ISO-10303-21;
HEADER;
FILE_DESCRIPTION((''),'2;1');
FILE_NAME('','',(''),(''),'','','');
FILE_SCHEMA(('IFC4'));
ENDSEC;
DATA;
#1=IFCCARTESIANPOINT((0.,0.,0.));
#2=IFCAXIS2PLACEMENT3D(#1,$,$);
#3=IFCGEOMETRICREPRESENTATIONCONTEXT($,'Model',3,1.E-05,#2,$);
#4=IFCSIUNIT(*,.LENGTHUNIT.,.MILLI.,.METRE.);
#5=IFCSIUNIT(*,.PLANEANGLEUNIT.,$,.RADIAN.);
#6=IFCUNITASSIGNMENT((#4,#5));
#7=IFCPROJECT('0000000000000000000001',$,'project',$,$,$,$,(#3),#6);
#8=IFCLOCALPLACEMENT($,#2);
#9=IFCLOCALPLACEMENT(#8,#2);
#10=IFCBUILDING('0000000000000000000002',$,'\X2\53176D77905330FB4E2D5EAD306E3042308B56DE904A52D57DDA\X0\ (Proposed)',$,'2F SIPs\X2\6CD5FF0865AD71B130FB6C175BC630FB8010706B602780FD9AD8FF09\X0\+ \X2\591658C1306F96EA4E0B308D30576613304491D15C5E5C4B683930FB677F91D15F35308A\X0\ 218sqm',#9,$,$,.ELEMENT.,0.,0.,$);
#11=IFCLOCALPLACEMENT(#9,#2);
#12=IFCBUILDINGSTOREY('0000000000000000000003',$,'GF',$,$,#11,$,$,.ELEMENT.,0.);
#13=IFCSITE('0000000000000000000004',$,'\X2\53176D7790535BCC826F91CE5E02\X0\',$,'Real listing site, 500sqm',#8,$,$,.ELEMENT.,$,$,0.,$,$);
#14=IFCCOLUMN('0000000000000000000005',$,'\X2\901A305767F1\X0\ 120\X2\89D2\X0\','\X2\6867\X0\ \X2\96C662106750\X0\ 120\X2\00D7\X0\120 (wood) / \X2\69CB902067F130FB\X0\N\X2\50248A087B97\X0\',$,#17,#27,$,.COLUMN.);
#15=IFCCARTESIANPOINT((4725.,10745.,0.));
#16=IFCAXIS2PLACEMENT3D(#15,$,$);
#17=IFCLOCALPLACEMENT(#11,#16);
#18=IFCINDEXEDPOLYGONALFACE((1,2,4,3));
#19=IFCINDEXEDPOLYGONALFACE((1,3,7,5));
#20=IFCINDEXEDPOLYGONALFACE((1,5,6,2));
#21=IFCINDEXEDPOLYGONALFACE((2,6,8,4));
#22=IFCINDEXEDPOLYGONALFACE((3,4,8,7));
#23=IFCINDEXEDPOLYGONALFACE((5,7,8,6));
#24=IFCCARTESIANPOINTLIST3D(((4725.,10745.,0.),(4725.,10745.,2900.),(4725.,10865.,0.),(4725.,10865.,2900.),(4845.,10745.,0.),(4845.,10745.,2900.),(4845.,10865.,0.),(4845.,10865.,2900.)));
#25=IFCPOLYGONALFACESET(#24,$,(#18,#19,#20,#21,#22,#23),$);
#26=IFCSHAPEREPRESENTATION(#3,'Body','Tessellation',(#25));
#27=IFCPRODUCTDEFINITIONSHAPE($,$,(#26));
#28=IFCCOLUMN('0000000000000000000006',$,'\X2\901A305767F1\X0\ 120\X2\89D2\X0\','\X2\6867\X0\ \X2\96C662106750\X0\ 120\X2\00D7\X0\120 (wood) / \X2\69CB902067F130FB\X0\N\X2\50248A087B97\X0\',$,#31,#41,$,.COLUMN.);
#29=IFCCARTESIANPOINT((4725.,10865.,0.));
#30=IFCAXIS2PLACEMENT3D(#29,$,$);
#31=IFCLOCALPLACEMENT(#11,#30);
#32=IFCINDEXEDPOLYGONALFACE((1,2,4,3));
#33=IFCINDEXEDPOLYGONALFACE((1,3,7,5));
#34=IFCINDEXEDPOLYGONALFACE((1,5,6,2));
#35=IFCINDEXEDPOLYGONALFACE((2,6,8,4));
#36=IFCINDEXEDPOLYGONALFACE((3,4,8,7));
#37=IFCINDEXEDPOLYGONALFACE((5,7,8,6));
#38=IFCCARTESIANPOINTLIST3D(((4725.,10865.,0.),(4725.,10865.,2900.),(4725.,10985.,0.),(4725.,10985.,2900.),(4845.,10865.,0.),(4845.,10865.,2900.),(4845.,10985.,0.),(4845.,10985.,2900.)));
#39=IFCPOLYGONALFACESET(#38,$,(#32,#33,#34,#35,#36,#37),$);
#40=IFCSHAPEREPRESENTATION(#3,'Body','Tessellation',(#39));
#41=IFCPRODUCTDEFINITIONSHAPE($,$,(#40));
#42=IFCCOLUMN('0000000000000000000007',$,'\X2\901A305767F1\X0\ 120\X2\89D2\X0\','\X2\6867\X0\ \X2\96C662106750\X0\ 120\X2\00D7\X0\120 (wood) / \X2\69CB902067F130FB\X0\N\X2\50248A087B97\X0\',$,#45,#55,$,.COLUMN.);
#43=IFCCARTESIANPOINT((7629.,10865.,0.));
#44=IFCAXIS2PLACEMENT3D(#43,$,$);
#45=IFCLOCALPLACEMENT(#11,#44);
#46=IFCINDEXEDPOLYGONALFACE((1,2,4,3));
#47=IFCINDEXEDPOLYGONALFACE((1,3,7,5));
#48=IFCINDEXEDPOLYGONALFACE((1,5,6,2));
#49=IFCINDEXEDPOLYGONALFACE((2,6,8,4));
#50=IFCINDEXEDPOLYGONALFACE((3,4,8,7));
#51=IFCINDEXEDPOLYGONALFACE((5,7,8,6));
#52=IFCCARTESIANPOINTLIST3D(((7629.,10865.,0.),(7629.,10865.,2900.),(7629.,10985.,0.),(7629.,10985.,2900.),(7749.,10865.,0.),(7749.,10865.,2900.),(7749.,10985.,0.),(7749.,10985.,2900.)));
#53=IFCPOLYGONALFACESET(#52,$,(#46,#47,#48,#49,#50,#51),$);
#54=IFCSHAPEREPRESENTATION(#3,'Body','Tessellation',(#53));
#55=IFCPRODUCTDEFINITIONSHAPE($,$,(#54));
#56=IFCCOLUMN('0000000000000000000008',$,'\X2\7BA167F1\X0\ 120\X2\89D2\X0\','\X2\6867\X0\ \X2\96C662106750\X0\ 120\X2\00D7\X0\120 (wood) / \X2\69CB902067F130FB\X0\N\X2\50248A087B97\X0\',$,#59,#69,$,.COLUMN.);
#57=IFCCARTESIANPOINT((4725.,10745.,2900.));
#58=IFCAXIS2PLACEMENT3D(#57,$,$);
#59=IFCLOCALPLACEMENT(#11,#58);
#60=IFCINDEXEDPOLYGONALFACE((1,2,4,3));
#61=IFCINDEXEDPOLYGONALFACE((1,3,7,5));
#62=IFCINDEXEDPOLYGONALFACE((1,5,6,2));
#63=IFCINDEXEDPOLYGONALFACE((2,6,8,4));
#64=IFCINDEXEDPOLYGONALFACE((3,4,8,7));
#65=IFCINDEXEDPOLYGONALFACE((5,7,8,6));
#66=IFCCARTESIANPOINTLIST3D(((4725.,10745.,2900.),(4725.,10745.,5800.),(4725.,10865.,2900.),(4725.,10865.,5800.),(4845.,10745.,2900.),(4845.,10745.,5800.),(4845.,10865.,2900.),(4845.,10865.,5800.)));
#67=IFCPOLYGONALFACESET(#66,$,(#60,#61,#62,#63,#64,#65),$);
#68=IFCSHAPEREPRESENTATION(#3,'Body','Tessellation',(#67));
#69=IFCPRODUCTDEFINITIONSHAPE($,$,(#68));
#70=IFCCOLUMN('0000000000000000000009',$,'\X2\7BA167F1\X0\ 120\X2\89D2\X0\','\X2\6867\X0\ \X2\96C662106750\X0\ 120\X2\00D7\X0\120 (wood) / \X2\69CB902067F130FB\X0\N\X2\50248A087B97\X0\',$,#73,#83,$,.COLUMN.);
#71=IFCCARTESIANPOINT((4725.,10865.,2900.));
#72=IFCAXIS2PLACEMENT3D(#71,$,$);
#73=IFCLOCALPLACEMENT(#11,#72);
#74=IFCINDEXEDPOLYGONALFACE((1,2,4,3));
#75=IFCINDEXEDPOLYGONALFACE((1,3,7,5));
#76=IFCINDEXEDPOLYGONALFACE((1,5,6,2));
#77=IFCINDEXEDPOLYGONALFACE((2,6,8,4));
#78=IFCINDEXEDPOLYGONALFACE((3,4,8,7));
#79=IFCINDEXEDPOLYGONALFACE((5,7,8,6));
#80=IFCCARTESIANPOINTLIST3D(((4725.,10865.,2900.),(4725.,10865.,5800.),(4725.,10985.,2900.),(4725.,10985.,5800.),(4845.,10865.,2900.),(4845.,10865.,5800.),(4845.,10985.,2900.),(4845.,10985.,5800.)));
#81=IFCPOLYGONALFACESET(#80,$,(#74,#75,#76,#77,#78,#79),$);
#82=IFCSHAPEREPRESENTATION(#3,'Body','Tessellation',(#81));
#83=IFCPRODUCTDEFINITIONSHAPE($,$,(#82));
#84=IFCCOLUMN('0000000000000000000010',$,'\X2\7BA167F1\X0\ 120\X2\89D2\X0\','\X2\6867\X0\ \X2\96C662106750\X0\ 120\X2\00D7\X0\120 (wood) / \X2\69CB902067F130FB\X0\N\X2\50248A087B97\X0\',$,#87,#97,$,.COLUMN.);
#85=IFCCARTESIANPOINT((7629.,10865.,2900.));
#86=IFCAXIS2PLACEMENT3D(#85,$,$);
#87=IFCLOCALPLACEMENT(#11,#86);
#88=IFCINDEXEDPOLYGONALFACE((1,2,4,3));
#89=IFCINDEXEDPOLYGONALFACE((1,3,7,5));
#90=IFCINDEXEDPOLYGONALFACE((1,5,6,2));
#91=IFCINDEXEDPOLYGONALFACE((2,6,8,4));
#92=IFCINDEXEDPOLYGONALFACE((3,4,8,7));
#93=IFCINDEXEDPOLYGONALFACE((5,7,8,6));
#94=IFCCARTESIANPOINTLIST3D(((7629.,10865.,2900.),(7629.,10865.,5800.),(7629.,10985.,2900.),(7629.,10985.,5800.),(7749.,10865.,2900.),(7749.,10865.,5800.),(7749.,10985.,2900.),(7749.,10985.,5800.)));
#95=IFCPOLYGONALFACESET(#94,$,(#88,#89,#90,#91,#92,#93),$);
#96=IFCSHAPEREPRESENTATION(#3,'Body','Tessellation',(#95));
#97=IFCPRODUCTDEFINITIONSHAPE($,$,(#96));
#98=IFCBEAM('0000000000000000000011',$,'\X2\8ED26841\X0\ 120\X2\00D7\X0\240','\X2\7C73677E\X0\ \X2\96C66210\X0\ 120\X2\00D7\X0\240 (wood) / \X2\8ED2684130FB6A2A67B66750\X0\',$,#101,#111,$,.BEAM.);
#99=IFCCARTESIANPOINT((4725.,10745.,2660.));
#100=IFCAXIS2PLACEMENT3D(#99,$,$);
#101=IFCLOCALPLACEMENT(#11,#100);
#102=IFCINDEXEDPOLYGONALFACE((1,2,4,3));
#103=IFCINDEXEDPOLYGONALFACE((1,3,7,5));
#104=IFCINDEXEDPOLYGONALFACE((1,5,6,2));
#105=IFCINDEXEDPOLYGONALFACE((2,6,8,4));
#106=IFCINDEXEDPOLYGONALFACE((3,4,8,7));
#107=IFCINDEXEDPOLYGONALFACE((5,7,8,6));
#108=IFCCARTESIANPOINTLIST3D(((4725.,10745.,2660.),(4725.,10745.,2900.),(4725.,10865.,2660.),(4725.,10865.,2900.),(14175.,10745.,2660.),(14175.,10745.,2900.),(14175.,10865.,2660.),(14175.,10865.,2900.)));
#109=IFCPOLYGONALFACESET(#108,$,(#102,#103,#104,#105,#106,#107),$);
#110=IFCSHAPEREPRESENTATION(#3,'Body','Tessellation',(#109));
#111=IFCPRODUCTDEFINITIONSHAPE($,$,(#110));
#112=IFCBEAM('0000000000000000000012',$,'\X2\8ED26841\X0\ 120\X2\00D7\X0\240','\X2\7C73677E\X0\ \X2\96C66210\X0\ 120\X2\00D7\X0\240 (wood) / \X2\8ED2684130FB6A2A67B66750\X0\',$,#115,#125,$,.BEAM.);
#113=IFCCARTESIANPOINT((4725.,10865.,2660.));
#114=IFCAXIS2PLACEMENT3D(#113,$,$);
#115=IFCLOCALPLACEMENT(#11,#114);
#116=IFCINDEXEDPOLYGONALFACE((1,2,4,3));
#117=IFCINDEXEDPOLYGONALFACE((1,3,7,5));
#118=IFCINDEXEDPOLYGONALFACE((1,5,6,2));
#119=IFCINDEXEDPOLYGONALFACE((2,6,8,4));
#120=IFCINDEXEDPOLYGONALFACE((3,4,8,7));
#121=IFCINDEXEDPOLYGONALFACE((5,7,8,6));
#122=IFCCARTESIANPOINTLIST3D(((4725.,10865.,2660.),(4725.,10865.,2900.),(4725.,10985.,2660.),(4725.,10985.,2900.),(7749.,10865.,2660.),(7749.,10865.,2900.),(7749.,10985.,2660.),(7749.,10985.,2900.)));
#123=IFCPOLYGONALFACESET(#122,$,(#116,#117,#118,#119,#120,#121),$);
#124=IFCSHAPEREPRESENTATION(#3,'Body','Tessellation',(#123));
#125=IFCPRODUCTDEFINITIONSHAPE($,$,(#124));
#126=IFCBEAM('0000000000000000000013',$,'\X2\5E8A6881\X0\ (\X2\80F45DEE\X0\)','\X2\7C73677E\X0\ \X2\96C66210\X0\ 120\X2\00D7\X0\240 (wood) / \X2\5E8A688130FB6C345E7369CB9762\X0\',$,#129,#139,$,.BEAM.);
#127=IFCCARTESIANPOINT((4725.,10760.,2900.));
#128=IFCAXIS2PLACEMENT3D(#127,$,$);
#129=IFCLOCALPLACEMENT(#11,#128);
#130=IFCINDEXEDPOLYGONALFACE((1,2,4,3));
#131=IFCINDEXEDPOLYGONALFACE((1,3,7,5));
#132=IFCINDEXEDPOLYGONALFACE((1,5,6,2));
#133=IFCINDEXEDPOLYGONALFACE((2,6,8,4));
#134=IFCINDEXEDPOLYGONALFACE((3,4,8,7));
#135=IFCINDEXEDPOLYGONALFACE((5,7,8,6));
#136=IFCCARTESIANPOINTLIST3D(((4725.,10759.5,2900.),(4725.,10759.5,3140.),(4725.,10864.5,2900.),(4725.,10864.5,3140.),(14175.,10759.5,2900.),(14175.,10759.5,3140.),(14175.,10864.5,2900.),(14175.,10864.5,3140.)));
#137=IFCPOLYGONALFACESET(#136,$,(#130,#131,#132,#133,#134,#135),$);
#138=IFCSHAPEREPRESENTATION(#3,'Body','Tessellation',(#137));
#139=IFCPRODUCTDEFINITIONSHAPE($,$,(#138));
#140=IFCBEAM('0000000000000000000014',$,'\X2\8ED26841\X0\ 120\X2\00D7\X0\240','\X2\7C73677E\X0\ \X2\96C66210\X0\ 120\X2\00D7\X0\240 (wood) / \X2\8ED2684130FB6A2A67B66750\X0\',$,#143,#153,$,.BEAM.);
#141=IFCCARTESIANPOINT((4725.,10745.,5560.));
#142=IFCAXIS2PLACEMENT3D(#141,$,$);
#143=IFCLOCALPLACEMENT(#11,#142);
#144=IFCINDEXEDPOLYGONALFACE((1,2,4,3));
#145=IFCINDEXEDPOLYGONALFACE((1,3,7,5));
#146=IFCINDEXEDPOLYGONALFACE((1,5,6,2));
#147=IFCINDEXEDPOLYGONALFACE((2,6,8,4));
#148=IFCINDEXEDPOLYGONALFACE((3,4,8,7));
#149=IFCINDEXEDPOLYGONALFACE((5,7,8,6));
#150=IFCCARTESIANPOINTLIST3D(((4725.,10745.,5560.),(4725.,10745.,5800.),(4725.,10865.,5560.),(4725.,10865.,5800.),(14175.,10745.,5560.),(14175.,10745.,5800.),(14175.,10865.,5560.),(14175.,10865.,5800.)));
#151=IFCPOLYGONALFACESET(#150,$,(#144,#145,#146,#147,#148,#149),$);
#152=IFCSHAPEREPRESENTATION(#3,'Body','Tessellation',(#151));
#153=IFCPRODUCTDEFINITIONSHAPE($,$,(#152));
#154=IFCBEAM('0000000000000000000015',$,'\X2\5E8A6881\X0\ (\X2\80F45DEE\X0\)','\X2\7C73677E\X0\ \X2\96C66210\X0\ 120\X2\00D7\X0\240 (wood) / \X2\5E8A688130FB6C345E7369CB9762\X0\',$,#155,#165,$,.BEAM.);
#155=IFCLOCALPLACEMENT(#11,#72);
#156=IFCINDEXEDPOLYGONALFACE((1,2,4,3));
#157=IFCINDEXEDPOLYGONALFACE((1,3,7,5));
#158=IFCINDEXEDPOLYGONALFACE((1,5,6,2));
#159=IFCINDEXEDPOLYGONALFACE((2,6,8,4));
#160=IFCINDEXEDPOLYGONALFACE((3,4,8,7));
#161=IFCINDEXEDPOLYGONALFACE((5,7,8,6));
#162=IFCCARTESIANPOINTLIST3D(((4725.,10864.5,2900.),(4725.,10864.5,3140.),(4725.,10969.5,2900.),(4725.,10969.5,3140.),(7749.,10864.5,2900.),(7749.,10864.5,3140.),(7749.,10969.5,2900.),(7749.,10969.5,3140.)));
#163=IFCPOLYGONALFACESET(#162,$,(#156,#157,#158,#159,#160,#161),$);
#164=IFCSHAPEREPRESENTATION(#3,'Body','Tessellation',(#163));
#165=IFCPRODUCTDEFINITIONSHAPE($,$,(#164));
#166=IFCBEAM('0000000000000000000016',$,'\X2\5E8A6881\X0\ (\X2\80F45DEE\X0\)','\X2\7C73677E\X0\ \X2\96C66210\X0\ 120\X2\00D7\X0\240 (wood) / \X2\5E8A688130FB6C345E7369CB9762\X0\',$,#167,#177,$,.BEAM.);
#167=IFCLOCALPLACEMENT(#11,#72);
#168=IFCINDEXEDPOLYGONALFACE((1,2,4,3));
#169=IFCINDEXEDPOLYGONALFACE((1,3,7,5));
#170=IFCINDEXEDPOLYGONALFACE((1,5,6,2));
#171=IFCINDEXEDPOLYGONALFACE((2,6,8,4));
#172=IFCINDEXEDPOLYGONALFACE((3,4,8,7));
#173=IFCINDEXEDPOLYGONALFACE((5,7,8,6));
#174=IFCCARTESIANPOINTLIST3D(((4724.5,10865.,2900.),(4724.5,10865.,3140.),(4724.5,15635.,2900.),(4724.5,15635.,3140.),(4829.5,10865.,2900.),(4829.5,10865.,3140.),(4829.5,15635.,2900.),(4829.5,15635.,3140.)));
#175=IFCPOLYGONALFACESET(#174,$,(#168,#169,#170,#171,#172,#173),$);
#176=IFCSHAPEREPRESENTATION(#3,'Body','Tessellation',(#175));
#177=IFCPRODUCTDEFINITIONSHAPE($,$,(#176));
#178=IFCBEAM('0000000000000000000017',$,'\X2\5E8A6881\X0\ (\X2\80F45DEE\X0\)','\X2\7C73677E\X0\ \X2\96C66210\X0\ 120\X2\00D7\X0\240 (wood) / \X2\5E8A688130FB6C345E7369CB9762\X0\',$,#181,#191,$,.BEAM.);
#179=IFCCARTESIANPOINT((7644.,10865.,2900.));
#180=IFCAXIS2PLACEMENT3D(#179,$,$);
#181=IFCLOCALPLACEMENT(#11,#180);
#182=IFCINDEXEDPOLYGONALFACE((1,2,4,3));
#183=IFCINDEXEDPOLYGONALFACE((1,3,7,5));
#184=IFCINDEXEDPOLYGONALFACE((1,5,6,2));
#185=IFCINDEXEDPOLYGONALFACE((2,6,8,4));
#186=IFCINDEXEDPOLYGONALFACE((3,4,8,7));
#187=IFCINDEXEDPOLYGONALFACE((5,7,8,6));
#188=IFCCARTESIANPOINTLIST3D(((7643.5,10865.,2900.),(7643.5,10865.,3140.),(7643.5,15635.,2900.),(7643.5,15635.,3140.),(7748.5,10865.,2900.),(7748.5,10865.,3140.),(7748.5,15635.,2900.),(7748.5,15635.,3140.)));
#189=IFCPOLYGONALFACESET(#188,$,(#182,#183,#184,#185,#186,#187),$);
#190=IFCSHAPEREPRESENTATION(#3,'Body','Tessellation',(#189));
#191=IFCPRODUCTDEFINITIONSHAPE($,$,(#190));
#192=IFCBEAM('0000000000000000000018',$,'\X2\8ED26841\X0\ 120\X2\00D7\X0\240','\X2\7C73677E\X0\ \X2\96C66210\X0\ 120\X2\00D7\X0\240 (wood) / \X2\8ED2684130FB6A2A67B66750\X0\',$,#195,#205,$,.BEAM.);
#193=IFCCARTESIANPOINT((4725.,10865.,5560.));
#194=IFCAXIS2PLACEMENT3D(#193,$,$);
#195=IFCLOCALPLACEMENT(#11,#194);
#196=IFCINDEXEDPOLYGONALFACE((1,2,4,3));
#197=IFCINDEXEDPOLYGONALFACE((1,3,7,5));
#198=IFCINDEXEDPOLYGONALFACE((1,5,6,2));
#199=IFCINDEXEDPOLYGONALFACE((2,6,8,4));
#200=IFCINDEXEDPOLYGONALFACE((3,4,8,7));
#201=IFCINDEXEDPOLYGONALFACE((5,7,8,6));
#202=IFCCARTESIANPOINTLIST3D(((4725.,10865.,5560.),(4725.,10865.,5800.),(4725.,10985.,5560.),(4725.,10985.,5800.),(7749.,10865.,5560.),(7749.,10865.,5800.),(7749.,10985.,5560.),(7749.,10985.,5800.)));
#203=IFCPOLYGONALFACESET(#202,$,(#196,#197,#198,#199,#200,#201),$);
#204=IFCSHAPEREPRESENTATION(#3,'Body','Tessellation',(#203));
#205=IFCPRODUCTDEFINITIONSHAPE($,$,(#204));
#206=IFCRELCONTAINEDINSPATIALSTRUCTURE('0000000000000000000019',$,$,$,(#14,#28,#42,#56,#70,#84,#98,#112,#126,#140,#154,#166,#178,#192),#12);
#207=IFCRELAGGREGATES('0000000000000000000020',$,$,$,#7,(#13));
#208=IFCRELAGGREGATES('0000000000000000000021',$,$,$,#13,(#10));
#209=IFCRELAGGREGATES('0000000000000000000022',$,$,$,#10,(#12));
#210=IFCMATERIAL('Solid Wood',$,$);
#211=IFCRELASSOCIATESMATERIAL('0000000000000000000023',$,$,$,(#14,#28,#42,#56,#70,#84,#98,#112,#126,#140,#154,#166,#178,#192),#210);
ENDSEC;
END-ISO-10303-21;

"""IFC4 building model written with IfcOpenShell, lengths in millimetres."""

from ifc_helpers import new_model, si_unit, frame, frame_2d, origin, place, context, project, spatial, rectangle, extrude, material, element, save


model = new_model("IFC4")

# Units and contexts
model_context = context("Model", 3, precision=1e-05, world=origin())
ifc_project = project(units=[si_unit("LENGTHUNIT", "METRE", prefix="MILLI"), si_unit("PLANEANGLEUNIT", "RADIAN")], contexts=[model_context])

# Site, building, storey
site_placement = place(None, origin())
site = spatial("IfcSite", under=ifc_project, at=site_placement, Name="北海道富良野市", ObjectType="Real listing site, 500sqm", CompositionType="ELEMENT", RefElevation=0.0)
building_placement = place(site_placement, origin())
building = spatial("IfcBuilding", under=site, at=building_placement, Name="北海道・中庭のある回遊動線 (Proposed)", ObjectType="2F SIPs法（断熱・気密・耐火性能高）+ 外壁は雪下ろし易い金属屋根・板金張り 218sqm", CompositionType="ELEMENT", ElevationOfRefHeight=0.0, ElevationOfTerrain=0.0)
storey_placement = place(building_placement, origin())
storey = spatial("IfcBuildingStorey", under=building, at=storey_placement, Name="GF", CompositionType="ELEMENT", Elevation=0.0)

# Columns
ifc_material_1 = material(Name="Solid Wood")
column_1_placement = place(storey_placement, frame((4725.0, 10745.0, 0.0)))
element("IfcColumn", 1, at=column_1_placement, inside=storey, material=ifc_material_1, Name="通し柱 120角", Description="桧 集成材 120×120 (wood) / 構造柱・N値計算", PredefinedType="COLUMN", context=model_context, shape_type="SweptSolid", body=[
    extrude(rectangle(XDim=120.0, YDim=120.0, at=frame_2d((60.0, 60.0))), frame((4725.0, 10745.0, 0.0)), (0.0, 0.0, 1.0), 2900.0),
])
column_2_placement = place(storey_placement, frame((4725.0, 10865.0, 0.0)))
element("IfcColumn", 2, at=column_2_placement, inside=storey, material=ifc_material_1, Name="通し柱 120角", Description="桧 集成材 120×120 (wood) / 構造柱・N値計算", PredefinedType="COLUMN", context=model_context, shape_type="SweptSolid", body=[
    extrude(rectangle(XDim=120.0, YDim=120.0, at=frame_2d((60.0, 60.0))), frame((4725.0, 10865.0, 0.0)), (0.0, 0.0, 1.0), 2900.0),
])
column_3_placement = place(storey_placement, frame((7629.0, 10865.0, 0.0)))
element("IfcColumn", 3, at=column_3_placement, inside=storey, material=ifc_material_1, Name="通し柱 120角", Description="桧 集成材 120×120 (wood) / 構造柱・N値計算", PredefinedType="COLUMN", context=model_context, shape_type="SweptSolid", body=[
    extrude(rectangle(XDim=120.0, YDim=120.0, at=frame_2d((60.0, 60.0))), frame((7629.0, 10865.0, 0.0)), (0.0, 0.0, 1.0), 2900.0),
])
column_4_placement = place(storey_placement, frame((4725.0, 10745.0, 2900.0)))
element("IfcColumn", 4, at=column_4_placement, inside=storey, material=ifc_material_1, Name="管柱 120角", Description="桧 集成材 120×120 (wood) / 構造柱・N値計算", PredefinedType="COLUMN", context=model_context, shape_type="SweptSolid", body=[
    extrude(rectangle(XDim=120.0, YDim=120.0, at=frame_2d((60.0, 60.0))), frame((4725.0, 10745.0, 2900.0)), (0.0, 0.0, 1.0), 2900.0),
])
column_5_placement = place(storey_placement, frame((4725.0, 10865.0, 2900.0)))
element("IfcColumn", 5, at=column_5_placement, inside=storey, material=ifc_material_1, Name="管柱 120角", Description="桧 集成材 120×120 (wood) / 構造柱・N値計算", PredefinedType="COLUMN", context=model_context, shape_type="SweptSolid", body=[
    extrude(rectangle(XDim=120.0, YDim=120.0, at=frame_2d((60.0, 60.0))), frame((4725.0, 10865.0, 2900.0)), (0.0, 0.0, 1.0), 2900.0),
])
column_6_placement = place(storey_placement, frame((7629.0, 10865.0, 2900.0)))
element("IfcColumn", 6, at=column_6_placement, inside=storey, material=ifc_material_1, Name="管柱 120角", Description="桧 集成材 120×120 (wood) / 構造柱・N値計算", PredefinedType="COLUMN", context=model_context, shape_type="SweptSolid", body=[
    extrude(rectangle(XDim=120.0, YDim=120.0, at=frame_2d((60.0, 60.0))), frame((7629.0, 10865.0, 2900.0)), (0.0, 0.0, 1.0), 2900.0),
])

# Beams
beam_1_placement = place(storey_placement, frame((4725.0, 10745.0, 2660.0)))
element("IfcBeam", 7, at=beam_1_placement, inside=storey, material=ifc_material_1, Name="軒桁 120×240", Description="米松 集成 120×240 (wood) / 軒桁・横架材", PredefinedType="BEAM", context=model_context, shape_type="SweptSolid", body=[
    extrude(rectangle(XDim=9450.0, YDim=120.0, at=frame_2d((4725.0, 60.0))), frame((4725.0, 10745.0, 2660.0)), (0.0, 0.0, 1.0), 240.0),
])
beam_2_placement = place(storey_placement, frame((4725.0, 10865.0, 2660.0)))
element("IfcBeam", 8, at=beam_2_placement, inside=storey, material=ifc_material_1, Name="軒桁 120×240", Description="米松 集成 120×240 (wood) / 軒桁・横架材", PredefinedType="BEAM", context=model_context, shape_type="SweptSolid", body=[
    extrude(rectangle(XDim=3024.0, YDim=120.0, at=frame_2d((1512.0, 60.0))), frame((4725.0, 10865.0, 2660.0)), (0.0, 0.0, 1.0), 240.0),
])
beam_3_placement = place(storey_placement, frame((4725.0, 10760.0, 2900.0)))
element("IfcBeam", 9, at=beam_3_placement, inside=storey, material=ifc_material_1, Name="床梁 (胴差)", Description="米松 集成 120×240 (wood) / 床梁・水平構面", PredefinedType="BEAM", context=model_context, shape_type="SweptSolid", body=[
    extrude(rectangle(XDim=9450.0, YDim=105.0, at=frame_2d((4725.0, 52.0))), frame((4725.0, 10760.0, 2900.0)), (0.0, 0.0, 1.0), 240.0),
])
beam_4_placement = place(storey_placement, frame((4725.0, 10745.0, 5560.0)))
element("IfcBeam", 10, at=beam_4_placement, inside=storey, material=ifc_material_1, Name="軒桁 120×240", Description="米松 集成 120×240 (wood) / 軒桁・横架材", PredefinedType="BEAM", context=model_context, shape_type="SweptSolid", body=[
    extrude(rectangle(XDim=9450.0, YDim=120.0, at=frame_2d((4725.0, 60.0))), frame((4725.0, 10745.0, 5560.0)), (0.0, 0.0, 1.0), 240.0),
])
beam_5_placement = place(storey_placement, frame((4725.0, 10865.0, 2900.0)))
element("IfcBeam", 11, at=beam_5_placement, inside=storey, material=ifc_material_1, Name="床梁 (胴差)", Description="米松 集成 120×240 (wood) / 床梁・水平構面", PredefinedType="BEAM", context=model_context, shape_type="SweptSolid", body=[
    extrude(rectangle(XDim=3024.0, YDim=105.0, at=frame_2d((1512.0, 52.0))), frame((4725.0, 10865.0, 2900.0)), (0.0, 0.0, 1.0), 240.0),
])
beam_6_placement = place(storey_placement, frame((4725.0, 10865.0, 2900.0)))
element("IfcBeam", 12, at=beam_6_placement, inside=storey, material=ifc_material_1, Name="床梁 (胴差)", Description="米松 集成 120×240 (wood) / 床梁・水平構面", PredefinedType="BEAM", context=model_context, shape_type="SweptSolid", body=[
    extrude(rectangle(XDim=105.0, YDim=4770.0, at=frame_2d((52.0, 2385.0))), frame((4725.0, 10865.0, 2900.0)), (0.0, 0.0, 1.0), 240.0),
])
beam_7_placement = place(storey_placement, frame((7644.0, 10865.0, 2900.0)))
element("IfcBeam", 13, at=beam_7_placement, inside=storey, material=ifc_material_1, Name="床梁 (胴差)", Description="米松 集成 120×240 (wood) / 床梁・水平構面", PredefinedType="BEAM", context=model_context, shape_type="SweptSolid", body=[
    extrude(rectangle(XDim=105.0, YDim=4770.0, at=frame_2d((52.0, 2385.0))), frame((7644.0, 10865.0, 2900.0)), (0.0, 0.0, 1.0), 240.0),
])
beam_8_placement = place(storey_placement, frame((4725.0, 10865.0, 5560.0)))
element("IfcBeam", 14, at=beam_8_placement, inside=storey, material=ifc_material_1, Name="軒桁 120×240", Description="米松 集成 120×240 (wood) / 軒桁・横架材", PredefinedType="BEAM", context=model_context, shape_type="SweptSolid", body=[
    extrude(rectangle(XDim=3024.0, YDim=120.0, at=frame_2d((1512.0, 60.0))), frame((4725.0, 10865.0, 5560.0)), (0.0, 0.0, 1.0), 240.0),
])

save(model, "model.ifc")
